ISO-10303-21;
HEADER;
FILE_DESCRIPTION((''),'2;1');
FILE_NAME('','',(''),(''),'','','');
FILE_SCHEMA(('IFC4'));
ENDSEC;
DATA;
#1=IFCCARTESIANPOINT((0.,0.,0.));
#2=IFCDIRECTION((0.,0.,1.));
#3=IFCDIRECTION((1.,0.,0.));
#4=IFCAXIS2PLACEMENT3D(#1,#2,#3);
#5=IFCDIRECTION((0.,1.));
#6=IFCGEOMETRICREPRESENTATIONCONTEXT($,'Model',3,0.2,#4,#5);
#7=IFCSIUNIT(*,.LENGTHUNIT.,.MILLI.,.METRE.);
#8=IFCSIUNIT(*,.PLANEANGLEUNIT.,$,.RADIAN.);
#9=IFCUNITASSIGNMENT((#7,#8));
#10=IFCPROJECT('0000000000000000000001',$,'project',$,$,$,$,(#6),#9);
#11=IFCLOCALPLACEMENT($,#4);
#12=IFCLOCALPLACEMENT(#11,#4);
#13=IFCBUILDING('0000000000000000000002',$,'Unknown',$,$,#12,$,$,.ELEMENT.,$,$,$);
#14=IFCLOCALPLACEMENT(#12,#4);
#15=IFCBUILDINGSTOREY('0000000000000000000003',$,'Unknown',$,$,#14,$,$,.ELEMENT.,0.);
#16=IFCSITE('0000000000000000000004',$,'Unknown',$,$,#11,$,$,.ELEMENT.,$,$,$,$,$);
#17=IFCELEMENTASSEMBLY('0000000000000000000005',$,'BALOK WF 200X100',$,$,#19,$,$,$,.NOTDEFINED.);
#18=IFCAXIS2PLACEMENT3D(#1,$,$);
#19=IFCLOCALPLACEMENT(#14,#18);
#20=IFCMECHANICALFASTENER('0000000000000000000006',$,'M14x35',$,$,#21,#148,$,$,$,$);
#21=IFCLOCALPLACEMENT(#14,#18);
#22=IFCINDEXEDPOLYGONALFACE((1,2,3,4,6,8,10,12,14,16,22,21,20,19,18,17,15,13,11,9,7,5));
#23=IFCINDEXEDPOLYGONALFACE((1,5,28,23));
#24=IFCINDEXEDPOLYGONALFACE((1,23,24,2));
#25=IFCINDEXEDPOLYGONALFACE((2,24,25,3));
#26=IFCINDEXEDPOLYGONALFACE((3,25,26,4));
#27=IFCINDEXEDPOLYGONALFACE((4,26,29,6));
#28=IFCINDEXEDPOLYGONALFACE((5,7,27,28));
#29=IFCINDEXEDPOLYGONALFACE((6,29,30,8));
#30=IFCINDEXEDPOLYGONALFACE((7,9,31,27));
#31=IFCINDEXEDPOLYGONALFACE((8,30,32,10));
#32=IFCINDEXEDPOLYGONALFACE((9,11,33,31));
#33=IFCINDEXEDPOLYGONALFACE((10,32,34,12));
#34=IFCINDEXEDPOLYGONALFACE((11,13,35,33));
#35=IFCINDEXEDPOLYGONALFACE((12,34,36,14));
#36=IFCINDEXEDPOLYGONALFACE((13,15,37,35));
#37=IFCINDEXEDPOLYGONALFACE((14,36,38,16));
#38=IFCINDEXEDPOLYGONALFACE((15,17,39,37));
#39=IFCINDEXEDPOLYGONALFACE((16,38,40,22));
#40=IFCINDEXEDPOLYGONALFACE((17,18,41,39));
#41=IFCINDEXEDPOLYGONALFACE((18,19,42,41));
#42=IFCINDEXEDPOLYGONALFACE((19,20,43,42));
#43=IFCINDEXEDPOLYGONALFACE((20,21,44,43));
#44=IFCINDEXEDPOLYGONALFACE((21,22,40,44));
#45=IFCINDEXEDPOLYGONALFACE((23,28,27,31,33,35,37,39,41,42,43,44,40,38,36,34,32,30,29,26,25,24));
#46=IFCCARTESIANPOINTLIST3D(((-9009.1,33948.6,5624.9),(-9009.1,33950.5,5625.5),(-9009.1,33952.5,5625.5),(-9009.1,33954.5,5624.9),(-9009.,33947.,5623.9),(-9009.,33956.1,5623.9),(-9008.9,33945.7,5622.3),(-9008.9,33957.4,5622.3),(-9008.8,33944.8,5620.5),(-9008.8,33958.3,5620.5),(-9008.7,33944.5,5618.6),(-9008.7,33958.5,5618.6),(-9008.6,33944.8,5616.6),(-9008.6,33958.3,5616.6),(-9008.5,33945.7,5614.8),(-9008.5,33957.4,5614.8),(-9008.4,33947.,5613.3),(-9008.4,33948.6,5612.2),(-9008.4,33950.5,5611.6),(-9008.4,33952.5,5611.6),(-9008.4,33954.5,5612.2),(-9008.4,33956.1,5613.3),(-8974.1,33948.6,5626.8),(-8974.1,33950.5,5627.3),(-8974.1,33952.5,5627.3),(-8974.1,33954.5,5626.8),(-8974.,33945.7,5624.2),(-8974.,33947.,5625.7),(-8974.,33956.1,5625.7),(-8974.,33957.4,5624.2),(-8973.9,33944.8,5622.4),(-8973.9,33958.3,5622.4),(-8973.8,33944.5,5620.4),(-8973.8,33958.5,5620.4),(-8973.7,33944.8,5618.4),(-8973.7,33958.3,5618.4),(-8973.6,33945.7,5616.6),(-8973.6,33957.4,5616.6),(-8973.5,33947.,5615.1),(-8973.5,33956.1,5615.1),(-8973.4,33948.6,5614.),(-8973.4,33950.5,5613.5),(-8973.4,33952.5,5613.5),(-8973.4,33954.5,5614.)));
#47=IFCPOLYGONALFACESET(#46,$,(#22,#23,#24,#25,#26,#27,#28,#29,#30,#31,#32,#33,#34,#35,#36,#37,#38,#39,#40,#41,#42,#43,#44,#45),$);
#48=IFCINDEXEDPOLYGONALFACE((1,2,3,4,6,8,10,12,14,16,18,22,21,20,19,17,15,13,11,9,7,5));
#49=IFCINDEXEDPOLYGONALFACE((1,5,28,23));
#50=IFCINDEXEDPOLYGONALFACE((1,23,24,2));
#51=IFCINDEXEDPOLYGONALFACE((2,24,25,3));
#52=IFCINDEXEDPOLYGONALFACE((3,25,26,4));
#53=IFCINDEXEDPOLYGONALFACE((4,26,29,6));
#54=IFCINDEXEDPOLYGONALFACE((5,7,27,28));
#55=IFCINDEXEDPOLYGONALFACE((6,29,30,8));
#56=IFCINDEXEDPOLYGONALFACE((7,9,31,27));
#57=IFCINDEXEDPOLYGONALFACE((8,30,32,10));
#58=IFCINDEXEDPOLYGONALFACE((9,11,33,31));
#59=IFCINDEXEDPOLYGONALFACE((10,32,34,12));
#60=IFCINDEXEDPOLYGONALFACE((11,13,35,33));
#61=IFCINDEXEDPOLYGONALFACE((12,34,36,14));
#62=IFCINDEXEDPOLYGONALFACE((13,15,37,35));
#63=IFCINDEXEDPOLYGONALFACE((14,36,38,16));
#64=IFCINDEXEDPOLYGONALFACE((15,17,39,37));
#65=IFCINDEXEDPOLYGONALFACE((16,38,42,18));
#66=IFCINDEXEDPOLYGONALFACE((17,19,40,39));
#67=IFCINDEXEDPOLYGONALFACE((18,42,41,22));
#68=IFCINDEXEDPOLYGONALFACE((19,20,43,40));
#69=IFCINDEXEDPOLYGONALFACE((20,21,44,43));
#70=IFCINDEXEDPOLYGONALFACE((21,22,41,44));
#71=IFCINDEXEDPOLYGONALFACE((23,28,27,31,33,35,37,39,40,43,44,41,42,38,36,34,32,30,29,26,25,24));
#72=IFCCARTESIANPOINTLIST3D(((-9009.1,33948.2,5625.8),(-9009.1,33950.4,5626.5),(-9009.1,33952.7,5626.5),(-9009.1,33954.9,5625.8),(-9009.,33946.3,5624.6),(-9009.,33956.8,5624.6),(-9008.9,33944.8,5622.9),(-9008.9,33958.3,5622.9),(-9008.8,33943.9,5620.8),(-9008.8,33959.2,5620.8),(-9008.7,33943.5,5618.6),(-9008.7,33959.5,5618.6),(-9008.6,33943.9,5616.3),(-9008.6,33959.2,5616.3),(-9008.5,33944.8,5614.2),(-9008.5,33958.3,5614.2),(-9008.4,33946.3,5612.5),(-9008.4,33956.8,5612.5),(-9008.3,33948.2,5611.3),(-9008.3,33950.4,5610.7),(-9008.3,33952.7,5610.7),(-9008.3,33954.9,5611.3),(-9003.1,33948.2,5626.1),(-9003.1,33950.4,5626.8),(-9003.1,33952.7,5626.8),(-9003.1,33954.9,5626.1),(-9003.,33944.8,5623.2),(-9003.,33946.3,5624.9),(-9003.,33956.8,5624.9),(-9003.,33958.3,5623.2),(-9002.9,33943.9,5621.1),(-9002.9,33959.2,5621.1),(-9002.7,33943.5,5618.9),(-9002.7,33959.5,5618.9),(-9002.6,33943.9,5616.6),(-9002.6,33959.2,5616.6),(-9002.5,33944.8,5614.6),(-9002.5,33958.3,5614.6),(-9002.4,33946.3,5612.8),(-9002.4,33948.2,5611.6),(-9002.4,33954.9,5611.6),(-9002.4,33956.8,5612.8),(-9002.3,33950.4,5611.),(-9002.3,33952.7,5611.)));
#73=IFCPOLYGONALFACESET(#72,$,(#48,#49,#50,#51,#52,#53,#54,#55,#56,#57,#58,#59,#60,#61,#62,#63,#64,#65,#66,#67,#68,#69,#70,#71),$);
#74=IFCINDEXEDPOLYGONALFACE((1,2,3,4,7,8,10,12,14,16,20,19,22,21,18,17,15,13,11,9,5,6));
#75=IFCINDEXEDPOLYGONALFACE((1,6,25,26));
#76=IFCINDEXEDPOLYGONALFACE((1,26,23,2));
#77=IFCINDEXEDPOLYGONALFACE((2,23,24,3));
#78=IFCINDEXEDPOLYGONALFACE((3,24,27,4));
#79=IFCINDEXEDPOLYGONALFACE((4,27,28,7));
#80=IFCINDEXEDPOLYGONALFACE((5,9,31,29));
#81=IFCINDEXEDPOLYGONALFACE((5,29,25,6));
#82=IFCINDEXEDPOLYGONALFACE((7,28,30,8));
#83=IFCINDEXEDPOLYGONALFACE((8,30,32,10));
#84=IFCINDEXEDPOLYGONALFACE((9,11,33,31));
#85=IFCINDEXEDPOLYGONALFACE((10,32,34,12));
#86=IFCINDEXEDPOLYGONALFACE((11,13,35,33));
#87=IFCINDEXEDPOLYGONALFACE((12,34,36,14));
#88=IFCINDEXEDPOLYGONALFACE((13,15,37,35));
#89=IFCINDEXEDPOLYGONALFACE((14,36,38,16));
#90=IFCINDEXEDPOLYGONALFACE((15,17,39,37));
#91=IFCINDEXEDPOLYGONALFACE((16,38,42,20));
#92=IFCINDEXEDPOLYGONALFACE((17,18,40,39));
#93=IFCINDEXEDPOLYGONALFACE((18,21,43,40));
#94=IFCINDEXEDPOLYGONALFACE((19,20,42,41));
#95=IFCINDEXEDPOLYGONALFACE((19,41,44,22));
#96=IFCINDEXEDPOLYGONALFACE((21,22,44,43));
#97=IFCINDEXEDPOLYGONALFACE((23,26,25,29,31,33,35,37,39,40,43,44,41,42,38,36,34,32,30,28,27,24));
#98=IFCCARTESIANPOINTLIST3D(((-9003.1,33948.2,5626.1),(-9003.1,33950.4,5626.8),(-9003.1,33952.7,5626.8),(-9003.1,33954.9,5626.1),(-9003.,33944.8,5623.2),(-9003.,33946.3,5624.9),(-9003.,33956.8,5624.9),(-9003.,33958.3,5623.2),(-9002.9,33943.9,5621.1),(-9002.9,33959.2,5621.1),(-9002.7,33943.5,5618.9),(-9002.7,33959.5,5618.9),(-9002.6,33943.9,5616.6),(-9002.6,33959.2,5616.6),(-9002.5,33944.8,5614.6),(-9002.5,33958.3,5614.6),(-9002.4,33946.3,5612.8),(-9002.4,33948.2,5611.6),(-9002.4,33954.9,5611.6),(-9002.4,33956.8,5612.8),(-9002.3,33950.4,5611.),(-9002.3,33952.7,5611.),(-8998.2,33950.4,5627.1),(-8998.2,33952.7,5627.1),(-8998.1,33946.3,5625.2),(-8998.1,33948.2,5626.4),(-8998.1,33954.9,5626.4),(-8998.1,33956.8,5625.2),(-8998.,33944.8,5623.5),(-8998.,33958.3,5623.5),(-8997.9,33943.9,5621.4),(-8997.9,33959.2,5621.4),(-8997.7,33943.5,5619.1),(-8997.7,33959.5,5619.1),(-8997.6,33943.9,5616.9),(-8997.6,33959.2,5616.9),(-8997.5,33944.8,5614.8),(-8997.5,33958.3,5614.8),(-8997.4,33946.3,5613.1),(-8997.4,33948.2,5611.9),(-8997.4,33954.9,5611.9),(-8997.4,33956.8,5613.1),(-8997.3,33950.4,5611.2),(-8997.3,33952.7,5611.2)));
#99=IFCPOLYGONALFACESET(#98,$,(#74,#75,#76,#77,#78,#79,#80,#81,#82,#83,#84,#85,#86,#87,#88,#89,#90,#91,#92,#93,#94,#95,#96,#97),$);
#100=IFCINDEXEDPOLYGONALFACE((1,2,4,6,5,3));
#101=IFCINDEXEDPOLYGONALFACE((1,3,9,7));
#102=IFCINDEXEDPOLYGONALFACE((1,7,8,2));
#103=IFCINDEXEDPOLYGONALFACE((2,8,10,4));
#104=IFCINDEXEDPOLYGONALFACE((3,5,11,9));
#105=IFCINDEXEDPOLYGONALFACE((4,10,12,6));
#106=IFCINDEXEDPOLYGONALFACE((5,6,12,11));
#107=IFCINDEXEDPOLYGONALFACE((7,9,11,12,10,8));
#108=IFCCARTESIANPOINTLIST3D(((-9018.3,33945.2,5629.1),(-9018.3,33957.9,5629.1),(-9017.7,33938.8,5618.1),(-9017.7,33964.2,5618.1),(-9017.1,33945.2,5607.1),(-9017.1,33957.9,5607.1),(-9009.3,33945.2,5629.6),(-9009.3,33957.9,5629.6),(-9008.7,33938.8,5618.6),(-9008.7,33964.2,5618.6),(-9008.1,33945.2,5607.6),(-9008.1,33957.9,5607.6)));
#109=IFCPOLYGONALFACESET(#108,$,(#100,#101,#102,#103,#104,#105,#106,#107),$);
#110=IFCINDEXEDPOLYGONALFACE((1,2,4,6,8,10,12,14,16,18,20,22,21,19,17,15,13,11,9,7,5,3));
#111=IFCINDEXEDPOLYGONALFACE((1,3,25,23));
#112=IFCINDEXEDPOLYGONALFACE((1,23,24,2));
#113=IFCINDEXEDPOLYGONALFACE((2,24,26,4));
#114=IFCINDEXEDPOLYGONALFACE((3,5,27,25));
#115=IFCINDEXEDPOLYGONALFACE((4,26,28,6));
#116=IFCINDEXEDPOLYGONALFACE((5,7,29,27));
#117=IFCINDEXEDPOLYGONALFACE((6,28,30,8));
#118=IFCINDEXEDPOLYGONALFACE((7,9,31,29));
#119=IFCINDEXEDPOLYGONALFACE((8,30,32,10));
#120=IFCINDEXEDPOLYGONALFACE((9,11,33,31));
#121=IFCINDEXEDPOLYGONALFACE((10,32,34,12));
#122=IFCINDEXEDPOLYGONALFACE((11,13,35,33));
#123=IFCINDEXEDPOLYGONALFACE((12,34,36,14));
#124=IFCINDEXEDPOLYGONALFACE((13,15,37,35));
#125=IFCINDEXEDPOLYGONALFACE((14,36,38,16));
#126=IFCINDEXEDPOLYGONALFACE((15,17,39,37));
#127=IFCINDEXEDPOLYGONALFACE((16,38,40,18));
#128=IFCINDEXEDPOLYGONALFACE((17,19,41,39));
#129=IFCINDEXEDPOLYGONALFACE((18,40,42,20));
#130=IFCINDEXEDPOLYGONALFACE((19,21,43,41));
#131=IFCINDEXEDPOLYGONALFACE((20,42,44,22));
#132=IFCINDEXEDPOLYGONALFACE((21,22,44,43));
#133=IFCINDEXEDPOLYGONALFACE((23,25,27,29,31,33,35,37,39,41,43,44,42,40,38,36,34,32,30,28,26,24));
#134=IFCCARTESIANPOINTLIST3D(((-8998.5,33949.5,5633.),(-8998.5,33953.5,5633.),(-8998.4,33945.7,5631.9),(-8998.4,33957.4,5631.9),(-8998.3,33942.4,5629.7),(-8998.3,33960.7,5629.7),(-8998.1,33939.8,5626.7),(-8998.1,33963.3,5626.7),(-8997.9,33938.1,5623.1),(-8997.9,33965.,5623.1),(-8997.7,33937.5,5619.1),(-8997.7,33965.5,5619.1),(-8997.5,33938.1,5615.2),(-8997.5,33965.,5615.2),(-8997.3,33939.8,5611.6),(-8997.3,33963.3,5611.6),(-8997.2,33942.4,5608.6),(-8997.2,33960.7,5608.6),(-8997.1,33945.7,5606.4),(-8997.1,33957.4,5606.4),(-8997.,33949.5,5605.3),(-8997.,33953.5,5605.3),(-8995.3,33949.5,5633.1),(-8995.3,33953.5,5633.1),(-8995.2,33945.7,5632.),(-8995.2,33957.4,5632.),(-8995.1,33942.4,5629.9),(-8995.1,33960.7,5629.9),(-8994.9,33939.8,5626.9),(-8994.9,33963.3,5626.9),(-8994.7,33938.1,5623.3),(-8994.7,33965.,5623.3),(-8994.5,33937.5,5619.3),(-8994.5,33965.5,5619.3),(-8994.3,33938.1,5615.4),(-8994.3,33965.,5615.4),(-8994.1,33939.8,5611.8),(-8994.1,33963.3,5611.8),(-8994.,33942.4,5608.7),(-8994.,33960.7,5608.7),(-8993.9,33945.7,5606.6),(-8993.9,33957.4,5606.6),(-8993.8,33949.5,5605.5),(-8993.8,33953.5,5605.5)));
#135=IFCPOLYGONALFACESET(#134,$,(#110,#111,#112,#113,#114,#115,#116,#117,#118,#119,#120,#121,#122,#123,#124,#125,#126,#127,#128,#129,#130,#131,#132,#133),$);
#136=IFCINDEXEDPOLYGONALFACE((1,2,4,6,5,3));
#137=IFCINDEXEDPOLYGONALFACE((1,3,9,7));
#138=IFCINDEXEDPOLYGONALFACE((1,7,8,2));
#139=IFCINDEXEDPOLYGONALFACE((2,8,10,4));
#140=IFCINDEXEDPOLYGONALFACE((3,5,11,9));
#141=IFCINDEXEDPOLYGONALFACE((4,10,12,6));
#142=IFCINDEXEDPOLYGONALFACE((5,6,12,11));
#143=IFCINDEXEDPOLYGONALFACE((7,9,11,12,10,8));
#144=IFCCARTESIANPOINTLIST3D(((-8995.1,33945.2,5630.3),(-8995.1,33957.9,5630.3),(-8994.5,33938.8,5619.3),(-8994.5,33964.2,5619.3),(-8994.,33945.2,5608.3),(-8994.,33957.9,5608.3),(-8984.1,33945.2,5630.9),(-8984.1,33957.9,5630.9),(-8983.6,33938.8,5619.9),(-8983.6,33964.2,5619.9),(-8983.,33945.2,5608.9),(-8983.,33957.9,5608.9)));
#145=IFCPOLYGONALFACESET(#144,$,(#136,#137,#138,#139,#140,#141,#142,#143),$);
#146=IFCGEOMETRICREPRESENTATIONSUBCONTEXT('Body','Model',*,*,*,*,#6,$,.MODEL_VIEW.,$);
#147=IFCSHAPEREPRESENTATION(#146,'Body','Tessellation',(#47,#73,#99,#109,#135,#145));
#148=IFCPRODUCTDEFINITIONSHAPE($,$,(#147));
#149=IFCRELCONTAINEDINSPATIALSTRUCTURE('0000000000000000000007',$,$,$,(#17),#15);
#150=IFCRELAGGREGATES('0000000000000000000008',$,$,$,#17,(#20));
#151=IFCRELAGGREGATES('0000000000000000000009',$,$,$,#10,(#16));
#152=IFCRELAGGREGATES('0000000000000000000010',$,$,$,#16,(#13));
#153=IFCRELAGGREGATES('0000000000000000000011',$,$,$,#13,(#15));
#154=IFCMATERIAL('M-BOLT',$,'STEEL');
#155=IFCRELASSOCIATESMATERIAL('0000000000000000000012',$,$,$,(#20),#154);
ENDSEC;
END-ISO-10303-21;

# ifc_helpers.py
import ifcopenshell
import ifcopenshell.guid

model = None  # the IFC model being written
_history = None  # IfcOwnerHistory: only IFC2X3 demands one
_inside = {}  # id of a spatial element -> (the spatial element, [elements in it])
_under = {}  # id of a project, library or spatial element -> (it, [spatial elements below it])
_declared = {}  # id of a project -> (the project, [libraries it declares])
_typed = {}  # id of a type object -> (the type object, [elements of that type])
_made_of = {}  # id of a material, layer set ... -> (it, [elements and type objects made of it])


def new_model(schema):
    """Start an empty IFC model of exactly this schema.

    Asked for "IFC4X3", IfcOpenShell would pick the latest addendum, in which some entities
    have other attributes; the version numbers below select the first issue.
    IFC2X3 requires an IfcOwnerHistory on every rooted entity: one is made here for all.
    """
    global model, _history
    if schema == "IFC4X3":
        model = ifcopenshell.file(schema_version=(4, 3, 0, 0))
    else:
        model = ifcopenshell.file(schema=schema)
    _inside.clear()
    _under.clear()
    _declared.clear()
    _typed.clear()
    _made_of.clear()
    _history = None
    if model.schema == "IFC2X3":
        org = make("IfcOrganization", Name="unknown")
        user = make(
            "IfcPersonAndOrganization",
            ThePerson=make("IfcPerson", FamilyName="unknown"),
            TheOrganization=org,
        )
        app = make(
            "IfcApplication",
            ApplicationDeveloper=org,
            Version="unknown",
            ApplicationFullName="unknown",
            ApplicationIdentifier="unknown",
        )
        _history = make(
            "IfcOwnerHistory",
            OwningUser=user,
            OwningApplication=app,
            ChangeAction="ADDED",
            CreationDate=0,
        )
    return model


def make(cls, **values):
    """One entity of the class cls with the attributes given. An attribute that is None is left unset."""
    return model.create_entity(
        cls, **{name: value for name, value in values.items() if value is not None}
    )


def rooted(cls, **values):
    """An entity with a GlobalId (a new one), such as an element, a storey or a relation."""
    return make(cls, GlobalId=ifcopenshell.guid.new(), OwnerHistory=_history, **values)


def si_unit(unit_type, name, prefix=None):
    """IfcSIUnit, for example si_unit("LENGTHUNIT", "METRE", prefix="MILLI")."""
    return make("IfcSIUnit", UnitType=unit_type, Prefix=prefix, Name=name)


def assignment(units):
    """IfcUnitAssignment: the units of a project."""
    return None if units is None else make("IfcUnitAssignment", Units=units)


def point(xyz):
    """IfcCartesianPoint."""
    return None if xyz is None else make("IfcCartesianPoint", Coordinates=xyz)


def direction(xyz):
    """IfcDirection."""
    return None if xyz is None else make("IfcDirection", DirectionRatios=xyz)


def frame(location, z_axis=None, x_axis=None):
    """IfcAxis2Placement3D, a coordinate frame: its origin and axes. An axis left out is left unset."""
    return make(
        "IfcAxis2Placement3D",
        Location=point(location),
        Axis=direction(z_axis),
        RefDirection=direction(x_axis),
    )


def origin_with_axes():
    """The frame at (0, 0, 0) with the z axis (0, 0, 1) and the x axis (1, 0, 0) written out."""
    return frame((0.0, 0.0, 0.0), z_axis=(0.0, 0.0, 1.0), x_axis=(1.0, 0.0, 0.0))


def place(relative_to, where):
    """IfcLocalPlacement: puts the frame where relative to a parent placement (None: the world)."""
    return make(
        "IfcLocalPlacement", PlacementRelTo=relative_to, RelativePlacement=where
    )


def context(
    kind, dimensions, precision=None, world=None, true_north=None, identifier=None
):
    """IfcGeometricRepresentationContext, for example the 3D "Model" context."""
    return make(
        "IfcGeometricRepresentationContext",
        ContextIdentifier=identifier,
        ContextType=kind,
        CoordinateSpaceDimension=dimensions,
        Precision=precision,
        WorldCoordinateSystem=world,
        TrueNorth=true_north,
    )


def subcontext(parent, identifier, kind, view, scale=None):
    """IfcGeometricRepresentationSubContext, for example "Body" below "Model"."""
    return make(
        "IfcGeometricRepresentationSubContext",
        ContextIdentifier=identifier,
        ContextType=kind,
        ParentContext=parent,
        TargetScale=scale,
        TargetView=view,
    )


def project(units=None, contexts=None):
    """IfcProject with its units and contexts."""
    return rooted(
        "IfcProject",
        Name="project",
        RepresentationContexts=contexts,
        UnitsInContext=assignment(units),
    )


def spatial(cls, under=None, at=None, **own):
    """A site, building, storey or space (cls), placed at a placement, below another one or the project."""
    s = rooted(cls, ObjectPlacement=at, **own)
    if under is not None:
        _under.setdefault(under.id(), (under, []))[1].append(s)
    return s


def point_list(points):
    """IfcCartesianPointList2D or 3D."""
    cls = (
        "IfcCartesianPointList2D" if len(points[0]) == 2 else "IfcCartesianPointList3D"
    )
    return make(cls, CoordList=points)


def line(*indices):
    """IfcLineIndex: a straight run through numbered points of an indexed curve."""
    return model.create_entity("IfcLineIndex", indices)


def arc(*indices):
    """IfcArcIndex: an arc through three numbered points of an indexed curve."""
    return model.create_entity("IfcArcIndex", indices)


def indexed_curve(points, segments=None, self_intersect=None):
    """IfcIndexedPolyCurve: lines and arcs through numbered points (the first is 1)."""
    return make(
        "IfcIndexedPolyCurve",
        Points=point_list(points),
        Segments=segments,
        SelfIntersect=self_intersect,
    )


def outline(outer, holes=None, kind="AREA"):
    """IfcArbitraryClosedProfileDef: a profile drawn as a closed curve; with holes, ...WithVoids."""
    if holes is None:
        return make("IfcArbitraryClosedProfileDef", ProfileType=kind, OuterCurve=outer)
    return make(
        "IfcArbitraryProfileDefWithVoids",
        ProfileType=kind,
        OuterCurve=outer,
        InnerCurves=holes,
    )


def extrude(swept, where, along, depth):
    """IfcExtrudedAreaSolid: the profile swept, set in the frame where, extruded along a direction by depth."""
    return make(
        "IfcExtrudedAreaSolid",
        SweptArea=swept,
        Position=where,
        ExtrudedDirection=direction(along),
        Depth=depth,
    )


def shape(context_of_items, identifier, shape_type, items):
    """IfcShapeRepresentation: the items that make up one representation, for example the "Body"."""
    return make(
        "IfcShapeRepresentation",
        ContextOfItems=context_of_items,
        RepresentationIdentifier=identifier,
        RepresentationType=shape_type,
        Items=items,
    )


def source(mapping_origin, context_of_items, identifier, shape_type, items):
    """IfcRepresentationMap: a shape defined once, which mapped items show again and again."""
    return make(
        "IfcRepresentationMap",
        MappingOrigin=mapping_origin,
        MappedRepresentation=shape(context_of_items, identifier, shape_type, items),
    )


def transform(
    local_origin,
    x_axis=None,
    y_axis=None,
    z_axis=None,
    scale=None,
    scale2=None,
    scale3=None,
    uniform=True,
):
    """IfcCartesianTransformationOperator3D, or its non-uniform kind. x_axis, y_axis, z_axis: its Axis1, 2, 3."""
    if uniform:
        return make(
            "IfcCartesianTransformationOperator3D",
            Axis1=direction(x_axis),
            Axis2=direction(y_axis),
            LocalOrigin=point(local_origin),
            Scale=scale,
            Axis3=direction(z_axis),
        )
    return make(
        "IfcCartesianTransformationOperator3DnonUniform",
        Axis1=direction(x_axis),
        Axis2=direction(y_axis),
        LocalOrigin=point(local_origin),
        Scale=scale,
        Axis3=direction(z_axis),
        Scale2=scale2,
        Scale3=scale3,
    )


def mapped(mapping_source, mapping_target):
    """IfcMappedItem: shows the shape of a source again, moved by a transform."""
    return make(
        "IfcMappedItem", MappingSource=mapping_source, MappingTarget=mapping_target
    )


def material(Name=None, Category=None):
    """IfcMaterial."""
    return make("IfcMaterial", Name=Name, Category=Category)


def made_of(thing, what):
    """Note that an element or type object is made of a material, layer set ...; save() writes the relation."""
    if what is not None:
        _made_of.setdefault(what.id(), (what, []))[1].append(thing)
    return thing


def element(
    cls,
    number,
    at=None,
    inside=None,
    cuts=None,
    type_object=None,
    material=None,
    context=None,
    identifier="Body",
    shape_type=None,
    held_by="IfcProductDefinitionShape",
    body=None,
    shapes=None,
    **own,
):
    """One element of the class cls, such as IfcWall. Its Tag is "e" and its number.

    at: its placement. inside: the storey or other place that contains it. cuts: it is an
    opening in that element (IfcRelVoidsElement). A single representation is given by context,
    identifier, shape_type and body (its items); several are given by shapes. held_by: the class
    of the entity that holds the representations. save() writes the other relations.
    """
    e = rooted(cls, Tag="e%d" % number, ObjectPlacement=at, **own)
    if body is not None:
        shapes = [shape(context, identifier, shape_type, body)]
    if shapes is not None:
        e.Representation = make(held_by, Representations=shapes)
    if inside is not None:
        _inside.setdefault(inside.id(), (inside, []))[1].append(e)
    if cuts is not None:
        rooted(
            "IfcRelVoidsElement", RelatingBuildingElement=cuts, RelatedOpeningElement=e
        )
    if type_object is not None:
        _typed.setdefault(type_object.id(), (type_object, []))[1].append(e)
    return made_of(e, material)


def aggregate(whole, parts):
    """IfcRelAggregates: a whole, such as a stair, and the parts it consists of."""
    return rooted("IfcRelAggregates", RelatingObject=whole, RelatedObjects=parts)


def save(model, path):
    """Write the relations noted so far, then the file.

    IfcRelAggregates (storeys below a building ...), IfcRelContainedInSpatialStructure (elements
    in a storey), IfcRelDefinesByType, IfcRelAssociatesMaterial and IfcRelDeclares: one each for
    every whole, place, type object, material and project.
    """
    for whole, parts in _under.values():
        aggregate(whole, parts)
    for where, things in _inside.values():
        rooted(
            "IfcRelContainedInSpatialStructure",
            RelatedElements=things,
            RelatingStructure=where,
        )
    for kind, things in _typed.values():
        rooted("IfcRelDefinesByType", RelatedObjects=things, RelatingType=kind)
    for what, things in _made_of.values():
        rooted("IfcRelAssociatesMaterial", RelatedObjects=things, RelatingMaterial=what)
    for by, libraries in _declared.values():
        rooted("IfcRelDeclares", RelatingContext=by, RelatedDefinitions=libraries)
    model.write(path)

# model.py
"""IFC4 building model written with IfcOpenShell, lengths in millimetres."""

from ifc_helpers import new_model, si_unit, direction, frame, origin_with_axes, place, context, subcontext, project, spatial, line, arc, indexed_curve, outline, extrude, source, transform, mapped, material, element, aggregate, save


model = new_model("IFC4")

# Units and contexts
model_context = context("Model", 3, precision=0.2, world=origin_with_axes(), true_north=direction((0.0, 1.0)))
body_context = subcontext(model_context, "Body", "Model", "MODEL_VIEW")
ifc_project = project(units=[si_unit("LENGTHUNIT", "METRE", prefix="MILLI"), si_unit("PLANEANGLEUNIT", "RADIAN")], contexts=[model_context])

# Site, building, storey
site_placement = place(None, origin_with_axes())
site = spatial("IfcSite", under=ifc_project, at=site_placement, Name="Unknown", CompositionType="ELEMENT")
building_placement = place(site_placement, origin_with_axes())
building = spatial("IfcBuilding", under=site, at=building_placement, Name="Unknown", CompositionType="ELEMENT")
storey_placement = place(building_placement, origin_with_axes())
storey = spatial("IfcBuildingStorey", under=building, at=storey_placement, Name="Unknown", CompositionType="ELEMENT", Elevation=0.0)

# Element assembly
assembly_1_placement = place(storey_placement, frame((-7044.1, 33866.5, 5721.5), z_axis=(0.0, 1.0, 0.0), x_axis=(-0.99863, 0.0, -0.052336)))
assembly_1 = element("IfcElementAssembly", 1, at=assembly_1_placement, inside=storey, Name="BALOK WF 200X100", PredefinedType="NOTDEFINED")

# Mechanical fastener
ifc_material_1 = material(Name="M-BOLT", Category="STEEL")
shared_shape_1 = source(origin_with_axes(), body_context, "Body", "SweptSolid", [
    extrude(outline(indexed_curve([(7.0, 0.0), (0.0, 7.0), (-7.0, 0.0), (0.0, -7.0)], segments=[arc(1, 2, 3), arc(3, 4, 1)])), frame((0.0, 0.0, -2.6), z_axis=(0.0, 0.0, -1.0), x_axis=(0.0, 1.0, 0.0)), (0.0, 0.0, 1.0), 35.0),
    extrude(outline(indexed_curve([(8.0, 0.0), (0.0, 8.0), (-8.0, 0.0), (0.0, -8.0)], segments=[arc(1, 2, 3), arc(3, 4, 1)])), frame((0.0, 0.0, -2.6), z_axis=(0.0, 0.0, -1.0), x_axis=(0.0, 1.0, 0.0)), (0.0, 0.0, 1.0), 6.0),
    extrude(outline(indexed_curve([(8.0, 0.0), (0.0, 8.0), (-8.0, 0.0), (0.0, -8.0)], segments=[arc(1, 2, 3), arc(3, 4, 1)])), frame((0.0, 0.0, -8.6), z_axis=(0.0, 0.0, -1.0), x_axis=(0.0, 1.0, 0.0)), (0.0, 0.0, 1.0), 5.0),
    extrude(outline(indexed_curve([(12.7, 0.0), (6.4, 11.0), (-6.4, 11.0), (-12.7, 0.0), (-6.4, -11.0), (6.4, -11.0)], segments=[line(1, 2, 3, 4, 5, 6, 1)])), frame((0.0, 0.0, 6.4), z_axis=(0.0, 0.0, -1.0), x_axis=(0.0, 1.0, 0.0)), (0.0, 0.0, 1.0), 9.0),
    extrude(outline(indexed_curve([(14.0, 0.0), (0.0, 14.0), (-14.0, 0.0), (0.0, -14.0)], segments=[arc(1, 2, 3), arc(3, 4, 1)])), frame((0.0, 0.0, -13.6), z_axis=(0.0, 0.0, -1.0), x_axis=(0.0, 1.0, 0.0)), (0.0, 0.0, 1.0), 3.2),
    extrude(outline(indexed_curve([(12.7, 0.0), (6.4, 11.0), (-6.4, 11.0), (-12.7, 0.0), (-6.4, -11.0), (6.4, -11.0)], segments=[line(1, 2, 3, 4, 5, 6, 1)])), frame((0.0, 0.0, -16.8), z_axis=(0.0, 0.0, -1.0), x_axis=(0.0, 1.0, 0.0)), (0.0, 0.0, 1.0), 11.0),
])
mechanical_fastener_1_placement = place(assembly_1_placement, frame((1969.9, 0.1, 85.0), z_axis=(1.0, 0.0, 0.000006), x_axis=(0.0, -1.0, 0.0)))
mechanical_fastener_1 = element("IfcMechanicalFastener", 2, at=mechanical_fastener_1_placement, material=ifc_material_1, Name="M14x35", context=body_context, shape_type="MappedRepresentation", body=[
    mapped(shared_shape_1, transform((0.0, 0.0, 0.0))),
])
aggregate(assembly_1, [mechanical_fastener_1])

save(model, "model.ifc")
